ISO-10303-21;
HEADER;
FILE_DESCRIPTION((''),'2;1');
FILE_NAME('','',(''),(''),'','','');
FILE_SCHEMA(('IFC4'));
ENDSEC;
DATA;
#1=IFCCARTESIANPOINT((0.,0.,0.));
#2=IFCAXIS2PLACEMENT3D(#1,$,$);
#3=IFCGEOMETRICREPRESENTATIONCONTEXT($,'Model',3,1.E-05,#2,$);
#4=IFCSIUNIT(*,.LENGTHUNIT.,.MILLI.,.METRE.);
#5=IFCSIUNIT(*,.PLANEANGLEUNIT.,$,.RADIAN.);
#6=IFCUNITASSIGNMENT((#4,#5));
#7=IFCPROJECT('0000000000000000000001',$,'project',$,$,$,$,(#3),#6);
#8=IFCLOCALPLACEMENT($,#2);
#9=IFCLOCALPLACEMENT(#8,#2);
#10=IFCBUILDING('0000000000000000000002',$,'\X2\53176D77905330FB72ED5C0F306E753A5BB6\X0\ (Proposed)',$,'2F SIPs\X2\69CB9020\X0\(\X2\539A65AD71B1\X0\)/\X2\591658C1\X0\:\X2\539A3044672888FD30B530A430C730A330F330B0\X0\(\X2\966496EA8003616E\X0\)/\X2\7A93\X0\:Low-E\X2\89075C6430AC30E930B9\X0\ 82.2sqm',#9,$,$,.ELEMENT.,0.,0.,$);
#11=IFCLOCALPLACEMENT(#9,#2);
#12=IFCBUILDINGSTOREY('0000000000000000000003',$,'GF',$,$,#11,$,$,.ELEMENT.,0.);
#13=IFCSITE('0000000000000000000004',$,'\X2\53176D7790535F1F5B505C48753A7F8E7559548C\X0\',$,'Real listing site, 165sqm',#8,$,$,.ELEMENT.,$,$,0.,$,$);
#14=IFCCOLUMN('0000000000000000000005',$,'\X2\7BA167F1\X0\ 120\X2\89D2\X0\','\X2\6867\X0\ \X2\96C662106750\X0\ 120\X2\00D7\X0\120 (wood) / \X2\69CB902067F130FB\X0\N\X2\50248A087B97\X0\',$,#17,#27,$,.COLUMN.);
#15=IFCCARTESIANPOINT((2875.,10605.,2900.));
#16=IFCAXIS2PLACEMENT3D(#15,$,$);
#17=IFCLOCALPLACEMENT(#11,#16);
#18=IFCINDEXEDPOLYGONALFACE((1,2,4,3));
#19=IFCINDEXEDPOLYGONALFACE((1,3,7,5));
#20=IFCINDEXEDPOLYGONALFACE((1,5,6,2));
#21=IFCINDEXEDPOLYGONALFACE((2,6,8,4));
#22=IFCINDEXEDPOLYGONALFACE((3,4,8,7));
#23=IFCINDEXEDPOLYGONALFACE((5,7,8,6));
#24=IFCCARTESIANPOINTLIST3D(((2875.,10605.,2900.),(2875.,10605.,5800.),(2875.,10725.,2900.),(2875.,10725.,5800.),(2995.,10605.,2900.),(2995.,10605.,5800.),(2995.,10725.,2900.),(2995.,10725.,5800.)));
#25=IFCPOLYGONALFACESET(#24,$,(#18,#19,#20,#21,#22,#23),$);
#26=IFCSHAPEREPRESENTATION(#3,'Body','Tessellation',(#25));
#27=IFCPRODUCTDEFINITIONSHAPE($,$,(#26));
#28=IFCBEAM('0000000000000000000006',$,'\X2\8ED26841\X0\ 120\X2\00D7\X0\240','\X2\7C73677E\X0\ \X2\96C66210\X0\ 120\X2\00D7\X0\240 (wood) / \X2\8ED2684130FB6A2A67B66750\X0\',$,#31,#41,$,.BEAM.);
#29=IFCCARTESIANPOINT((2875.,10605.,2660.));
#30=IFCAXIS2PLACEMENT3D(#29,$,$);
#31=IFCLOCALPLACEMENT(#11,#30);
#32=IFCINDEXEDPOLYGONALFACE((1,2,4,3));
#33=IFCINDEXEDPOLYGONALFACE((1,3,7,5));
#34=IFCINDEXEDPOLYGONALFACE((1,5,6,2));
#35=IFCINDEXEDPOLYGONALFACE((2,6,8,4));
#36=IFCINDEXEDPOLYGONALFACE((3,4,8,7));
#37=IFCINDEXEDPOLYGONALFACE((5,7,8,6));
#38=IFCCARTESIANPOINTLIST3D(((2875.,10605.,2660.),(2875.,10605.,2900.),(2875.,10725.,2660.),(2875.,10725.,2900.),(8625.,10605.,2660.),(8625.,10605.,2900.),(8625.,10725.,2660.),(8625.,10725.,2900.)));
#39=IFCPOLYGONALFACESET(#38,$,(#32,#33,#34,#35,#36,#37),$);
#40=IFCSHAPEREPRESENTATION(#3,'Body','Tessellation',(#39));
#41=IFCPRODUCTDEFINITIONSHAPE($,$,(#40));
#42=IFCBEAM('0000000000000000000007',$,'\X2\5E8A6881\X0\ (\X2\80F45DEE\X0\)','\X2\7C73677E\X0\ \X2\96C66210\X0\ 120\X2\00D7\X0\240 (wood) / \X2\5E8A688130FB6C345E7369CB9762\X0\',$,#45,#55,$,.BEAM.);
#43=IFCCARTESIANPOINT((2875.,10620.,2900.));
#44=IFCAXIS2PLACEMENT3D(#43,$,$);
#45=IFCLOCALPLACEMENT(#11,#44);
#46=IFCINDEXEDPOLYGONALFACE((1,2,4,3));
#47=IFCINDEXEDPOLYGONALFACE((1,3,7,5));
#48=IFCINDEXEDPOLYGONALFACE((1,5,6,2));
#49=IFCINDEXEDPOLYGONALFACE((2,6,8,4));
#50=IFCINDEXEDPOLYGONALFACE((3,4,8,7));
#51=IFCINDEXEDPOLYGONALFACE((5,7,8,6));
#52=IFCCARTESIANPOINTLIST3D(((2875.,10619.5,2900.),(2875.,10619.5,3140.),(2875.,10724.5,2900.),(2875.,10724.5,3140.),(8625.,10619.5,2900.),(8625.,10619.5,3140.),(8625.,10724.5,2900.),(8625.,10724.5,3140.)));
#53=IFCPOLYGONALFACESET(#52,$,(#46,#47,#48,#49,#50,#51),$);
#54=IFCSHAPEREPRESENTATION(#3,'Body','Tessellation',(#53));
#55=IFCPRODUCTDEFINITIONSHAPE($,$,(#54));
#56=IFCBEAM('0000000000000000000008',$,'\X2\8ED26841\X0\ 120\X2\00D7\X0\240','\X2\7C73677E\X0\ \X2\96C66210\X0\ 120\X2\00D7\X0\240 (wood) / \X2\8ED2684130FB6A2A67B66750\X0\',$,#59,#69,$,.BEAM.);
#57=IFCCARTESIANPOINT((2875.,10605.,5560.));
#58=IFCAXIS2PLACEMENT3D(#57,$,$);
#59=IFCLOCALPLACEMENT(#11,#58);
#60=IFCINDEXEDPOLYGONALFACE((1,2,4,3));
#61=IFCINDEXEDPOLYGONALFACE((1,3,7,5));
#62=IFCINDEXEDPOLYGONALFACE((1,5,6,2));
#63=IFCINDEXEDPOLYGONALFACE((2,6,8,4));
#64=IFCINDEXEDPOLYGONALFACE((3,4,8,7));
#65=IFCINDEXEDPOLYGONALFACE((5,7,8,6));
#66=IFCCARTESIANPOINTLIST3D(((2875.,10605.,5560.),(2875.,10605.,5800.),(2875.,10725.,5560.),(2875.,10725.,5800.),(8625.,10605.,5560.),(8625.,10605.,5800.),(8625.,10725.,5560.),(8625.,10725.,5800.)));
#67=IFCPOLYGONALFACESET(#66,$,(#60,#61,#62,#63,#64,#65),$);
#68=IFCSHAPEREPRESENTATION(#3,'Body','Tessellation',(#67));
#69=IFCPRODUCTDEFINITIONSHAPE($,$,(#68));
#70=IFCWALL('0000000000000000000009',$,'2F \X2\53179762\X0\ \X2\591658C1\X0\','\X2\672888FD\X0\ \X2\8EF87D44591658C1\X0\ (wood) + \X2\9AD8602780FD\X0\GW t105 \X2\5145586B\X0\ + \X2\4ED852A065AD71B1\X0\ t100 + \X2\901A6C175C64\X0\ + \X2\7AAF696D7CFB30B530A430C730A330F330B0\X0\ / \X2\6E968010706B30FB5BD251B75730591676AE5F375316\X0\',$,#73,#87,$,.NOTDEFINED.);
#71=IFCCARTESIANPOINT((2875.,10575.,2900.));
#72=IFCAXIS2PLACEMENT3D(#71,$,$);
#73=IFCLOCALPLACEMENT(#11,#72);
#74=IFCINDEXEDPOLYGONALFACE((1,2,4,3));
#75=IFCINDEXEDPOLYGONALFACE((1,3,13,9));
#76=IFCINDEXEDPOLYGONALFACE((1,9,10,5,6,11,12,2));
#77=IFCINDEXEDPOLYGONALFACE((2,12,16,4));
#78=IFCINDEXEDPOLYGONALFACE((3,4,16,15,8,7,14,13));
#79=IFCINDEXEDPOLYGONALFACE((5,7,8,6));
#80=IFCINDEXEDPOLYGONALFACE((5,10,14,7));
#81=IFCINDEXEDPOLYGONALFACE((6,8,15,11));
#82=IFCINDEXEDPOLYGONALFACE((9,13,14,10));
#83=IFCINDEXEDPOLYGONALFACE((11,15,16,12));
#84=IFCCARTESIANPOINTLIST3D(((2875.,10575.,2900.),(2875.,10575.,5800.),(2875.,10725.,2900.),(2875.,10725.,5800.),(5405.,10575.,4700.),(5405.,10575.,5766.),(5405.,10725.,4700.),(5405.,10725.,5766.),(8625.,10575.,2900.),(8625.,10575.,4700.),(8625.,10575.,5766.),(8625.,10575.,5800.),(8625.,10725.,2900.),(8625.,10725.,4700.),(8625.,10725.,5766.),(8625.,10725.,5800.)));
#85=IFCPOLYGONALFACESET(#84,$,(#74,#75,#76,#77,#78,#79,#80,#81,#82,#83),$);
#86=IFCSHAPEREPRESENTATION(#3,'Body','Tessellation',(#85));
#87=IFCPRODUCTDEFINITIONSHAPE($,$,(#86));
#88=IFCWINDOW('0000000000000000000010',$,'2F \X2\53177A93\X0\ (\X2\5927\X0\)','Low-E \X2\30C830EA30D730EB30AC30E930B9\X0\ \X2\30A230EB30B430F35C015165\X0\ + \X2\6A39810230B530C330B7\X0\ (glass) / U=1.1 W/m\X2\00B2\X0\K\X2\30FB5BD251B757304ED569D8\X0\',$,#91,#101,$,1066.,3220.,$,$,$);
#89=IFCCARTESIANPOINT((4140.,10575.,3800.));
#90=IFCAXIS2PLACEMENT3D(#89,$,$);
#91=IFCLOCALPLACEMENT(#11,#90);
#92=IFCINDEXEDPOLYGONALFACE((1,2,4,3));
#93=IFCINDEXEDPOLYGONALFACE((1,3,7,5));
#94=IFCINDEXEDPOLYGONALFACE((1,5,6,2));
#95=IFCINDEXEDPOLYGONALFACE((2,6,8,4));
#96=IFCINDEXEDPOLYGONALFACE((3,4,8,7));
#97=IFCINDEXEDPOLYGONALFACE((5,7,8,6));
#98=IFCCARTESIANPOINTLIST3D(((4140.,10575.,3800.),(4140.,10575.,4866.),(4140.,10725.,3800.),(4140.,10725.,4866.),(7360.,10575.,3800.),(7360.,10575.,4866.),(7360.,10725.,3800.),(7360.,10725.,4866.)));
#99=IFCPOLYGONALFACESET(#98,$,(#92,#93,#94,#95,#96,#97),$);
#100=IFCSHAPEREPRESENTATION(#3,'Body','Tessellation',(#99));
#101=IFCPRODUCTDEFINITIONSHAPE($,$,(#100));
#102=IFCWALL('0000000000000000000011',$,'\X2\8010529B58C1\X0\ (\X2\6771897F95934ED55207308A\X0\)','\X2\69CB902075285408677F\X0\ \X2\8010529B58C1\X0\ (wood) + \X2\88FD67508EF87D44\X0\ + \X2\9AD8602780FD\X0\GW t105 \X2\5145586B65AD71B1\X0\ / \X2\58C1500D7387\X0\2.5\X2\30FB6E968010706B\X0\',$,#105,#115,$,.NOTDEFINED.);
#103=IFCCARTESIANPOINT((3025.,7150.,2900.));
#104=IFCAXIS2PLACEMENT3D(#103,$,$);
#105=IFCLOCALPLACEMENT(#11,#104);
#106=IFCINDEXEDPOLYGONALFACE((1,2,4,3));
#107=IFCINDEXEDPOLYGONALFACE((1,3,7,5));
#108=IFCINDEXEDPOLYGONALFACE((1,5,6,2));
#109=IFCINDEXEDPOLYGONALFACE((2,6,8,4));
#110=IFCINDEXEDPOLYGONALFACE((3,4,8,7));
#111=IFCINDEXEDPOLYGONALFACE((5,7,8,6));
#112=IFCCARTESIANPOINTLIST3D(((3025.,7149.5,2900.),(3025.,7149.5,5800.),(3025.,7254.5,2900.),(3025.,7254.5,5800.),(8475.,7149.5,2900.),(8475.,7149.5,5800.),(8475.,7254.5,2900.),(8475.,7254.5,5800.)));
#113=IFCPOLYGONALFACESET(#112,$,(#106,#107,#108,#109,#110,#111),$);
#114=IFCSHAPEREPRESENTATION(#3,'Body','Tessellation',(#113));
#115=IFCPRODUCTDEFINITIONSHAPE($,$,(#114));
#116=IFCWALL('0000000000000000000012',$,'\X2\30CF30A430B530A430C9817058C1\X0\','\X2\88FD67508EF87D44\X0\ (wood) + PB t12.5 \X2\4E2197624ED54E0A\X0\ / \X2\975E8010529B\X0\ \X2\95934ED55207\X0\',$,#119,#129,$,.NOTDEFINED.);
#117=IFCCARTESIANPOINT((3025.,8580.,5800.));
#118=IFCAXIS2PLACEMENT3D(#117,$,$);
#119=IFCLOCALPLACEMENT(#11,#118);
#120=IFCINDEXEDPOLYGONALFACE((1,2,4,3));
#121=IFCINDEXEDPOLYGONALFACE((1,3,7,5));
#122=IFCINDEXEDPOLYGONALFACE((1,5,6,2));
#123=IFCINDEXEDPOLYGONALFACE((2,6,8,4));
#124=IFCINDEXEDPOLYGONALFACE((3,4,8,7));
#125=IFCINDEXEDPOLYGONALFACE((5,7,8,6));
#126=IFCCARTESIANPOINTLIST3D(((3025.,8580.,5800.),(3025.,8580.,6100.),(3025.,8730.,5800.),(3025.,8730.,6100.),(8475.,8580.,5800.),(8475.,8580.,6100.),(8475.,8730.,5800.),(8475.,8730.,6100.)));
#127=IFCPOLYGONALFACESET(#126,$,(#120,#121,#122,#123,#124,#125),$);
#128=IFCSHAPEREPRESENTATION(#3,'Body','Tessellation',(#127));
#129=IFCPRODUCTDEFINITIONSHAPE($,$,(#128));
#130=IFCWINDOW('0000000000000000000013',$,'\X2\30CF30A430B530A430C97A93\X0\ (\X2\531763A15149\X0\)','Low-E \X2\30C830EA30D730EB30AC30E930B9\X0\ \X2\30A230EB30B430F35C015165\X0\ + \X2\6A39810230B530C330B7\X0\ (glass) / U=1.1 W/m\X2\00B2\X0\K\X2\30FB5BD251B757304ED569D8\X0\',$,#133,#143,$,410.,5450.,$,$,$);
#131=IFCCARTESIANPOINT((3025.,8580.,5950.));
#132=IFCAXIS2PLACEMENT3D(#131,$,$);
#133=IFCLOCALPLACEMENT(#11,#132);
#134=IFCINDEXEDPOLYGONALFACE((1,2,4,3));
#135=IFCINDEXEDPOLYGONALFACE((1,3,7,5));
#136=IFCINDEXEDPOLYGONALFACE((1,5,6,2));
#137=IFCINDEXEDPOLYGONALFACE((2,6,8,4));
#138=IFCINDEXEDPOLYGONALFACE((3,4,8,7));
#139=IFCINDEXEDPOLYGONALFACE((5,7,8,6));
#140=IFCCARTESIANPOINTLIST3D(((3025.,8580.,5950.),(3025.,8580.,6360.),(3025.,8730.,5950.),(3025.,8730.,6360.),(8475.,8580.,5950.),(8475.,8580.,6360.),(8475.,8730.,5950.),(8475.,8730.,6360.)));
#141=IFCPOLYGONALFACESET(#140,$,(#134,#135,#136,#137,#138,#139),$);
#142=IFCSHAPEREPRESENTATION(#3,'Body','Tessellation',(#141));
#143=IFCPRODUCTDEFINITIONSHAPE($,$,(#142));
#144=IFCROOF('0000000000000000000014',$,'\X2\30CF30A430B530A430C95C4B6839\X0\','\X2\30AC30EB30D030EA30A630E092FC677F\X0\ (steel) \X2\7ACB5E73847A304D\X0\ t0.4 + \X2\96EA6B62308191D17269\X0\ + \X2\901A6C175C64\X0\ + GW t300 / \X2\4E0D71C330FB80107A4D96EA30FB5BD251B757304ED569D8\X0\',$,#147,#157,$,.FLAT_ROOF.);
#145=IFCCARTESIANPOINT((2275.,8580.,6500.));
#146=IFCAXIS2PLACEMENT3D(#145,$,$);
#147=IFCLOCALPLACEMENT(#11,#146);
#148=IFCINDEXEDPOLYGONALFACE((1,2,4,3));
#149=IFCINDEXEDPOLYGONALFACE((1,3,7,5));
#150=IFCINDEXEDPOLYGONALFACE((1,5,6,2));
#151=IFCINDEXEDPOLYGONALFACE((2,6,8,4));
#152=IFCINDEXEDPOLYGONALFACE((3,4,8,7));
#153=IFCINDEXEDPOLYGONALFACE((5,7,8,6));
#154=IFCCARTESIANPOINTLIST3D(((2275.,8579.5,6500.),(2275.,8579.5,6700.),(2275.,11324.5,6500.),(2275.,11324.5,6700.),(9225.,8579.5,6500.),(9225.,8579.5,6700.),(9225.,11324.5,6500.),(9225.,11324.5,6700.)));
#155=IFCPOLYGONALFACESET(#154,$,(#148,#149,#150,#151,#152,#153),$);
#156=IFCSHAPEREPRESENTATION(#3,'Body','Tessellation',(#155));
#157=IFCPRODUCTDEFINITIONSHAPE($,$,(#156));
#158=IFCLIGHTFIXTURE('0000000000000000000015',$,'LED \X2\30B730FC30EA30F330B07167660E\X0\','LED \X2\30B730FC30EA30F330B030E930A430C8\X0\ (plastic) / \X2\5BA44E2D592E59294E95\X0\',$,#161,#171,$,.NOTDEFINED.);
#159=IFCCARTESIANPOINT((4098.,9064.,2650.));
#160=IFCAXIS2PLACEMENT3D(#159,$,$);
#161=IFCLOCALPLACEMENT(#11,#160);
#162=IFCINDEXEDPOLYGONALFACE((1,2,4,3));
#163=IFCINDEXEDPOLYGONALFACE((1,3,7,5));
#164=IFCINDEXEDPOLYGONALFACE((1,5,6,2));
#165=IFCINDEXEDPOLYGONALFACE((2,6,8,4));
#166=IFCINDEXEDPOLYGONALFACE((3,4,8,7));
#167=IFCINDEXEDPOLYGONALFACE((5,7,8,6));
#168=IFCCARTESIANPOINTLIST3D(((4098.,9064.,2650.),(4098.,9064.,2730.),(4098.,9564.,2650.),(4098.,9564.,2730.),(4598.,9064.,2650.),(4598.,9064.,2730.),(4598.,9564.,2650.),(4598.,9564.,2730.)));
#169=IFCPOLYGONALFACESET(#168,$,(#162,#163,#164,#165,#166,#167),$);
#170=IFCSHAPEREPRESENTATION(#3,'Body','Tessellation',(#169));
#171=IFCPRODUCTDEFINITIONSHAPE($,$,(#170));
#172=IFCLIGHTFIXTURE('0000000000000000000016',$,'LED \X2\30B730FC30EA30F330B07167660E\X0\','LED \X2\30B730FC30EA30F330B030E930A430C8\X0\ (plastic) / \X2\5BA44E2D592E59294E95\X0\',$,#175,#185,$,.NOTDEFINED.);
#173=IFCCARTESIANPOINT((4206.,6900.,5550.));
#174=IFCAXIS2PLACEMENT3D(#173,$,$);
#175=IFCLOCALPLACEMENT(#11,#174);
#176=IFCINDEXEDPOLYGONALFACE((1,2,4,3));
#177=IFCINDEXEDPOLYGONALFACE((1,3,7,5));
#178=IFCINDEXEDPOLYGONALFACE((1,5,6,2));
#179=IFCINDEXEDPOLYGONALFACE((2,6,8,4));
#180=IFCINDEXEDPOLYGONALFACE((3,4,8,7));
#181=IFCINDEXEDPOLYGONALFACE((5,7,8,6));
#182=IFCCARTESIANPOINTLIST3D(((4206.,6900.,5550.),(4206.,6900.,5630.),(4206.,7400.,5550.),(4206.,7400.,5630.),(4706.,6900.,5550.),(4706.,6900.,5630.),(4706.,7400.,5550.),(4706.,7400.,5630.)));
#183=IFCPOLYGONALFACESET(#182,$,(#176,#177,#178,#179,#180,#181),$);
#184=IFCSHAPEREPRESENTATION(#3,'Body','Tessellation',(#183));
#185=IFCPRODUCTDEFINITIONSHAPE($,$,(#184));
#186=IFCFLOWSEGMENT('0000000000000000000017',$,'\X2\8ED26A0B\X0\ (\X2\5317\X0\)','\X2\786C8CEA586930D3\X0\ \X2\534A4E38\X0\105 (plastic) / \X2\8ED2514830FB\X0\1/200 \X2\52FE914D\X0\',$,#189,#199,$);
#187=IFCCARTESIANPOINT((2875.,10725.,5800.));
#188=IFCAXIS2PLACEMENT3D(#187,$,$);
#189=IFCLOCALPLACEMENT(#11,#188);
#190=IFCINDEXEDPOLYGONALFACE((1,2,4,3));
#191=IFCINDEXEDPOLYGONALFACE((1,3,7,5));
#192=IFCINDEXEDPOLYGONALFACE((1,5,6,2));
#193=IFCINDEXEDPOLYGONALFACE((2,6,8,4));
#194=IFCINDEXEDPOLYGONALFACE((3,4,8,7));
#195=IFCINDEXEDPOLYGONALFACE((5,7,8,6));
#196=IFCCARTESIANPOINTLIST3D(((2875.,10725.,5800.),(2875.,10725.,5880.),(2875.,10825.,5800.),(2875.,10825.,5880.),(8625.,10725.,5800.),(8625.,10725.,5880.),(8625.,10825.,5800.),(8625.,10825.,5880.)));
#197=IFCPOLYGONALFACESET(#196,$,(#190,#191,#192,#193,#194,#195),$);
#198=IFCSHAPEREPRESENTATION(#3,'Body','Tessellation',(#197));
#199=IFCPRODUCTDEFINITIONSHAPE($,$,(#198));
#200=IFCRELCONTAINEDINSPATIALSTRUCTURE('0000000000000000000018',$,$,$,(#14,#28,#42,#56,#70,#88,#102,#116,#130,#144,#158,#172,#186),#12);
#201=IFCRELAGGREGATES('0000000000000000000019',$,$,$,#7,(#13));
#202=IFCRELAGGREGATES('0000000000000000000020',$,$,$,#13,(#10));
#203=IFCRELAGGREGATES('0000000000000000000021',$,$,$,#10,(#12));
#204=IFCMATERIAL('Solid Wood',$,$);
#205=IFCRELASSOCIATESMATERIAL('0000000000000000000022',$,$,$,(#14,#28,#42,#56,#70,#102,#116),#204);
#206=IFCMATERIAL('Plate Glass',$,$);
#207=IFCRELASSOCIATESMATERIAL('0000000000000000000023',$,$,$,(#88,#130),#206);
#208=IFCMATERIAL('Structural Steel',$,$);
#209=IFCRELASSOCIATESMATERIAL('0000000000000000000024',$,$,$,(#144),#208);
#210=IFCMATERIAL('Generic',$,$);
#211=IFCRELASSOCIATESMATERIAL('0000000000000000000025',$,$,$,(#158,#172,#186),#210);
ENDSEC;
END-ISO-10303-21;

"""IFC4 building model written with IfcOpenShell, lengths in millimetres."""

from ifc_helpers import new_model, si_unit, frame, frame_2d, origin, place, context, project, spatial, rectangle, extrude, material, element, fill, save


model = new_model("IFC4")

# Units and contexts
model_context = context("Model", 3, precision=1e-05, world=origin())
ifc_project = project(units=[si_unit("LENGTHUNIT", "METRE", prefix="MILLI"), si_unit("PLANEANGLEUNIT", "RADIAN")], contexts=[model_context])

# Site, building, storey
site_placement = place(None, origin())
site = spatial("IfcSite", under=ifc_project, at=site_placement, Name="北海道弟子屈町美留和", ObjectType="Real listing site, 165sqm", CompositionType="ELEMENT", RefElevation=0.0)
building_placement = place(site_placement, origin())
building = spatial("IfcBuilding", under=site, at=building_placement, Name="北海道・狭小の町家 (Proposed)", ObjectType="2F SIPs構造(厚断熱)/外壁:厚い木製サイディング(除雪考慮)/窓:Low-E複層ガラス 82.2sqm", CompositionType="ELEMENT", ElevationOfRefHeight=0.0, ElevationOfTerrain=0.0)
storey_placement = place(building_placement, origin())
storey = spatial("IfcBuildingStorey", under=building, at=storey_placement, Name="GF", CompositionType="ELEMENT", Elevation=0.0)

# Column
ifc_material_1 = material(Name="Solid Wood")
column_1_placement = place(storey_placement, frame((2875.0, 10605.0, 2900.0)))
element("IfcColumn", 1, at=column_1_placement, inside=storey, material=ifc_material_1, Name="管柱 120角", Description="桧 集成材 120×120 (wood) / 構造柱・N値計算", PredefinedType="COLUMN", context=model_context, shape_type="SweptSolid", body=[
    extrude(rectangle(XDim=120.0, YDim=120.0, at=frame_2d((60.0, 60.0))), frame((2875.0, 10605.0, 2900.0)), (0.0, 0.0, 1.0), 2900.0),
])

# Beams
beam_1_placement = place(storey_placement, frame((2875.0, 10605.0, 2660.0)))
element("IfcBeam", 2, at=beam_1_placement, inside=storey, material=ifc_material_1, Name="軒桁 120×240", Description="米松 集成 120×240 (wood) / 軒桁・横架材", PredefinedType="BEAM", context=model_context, shape_type="SweptSolid", body=[
    extrude(rectangle(XDim=5750.0, YDim=120.0, at=frame_2d((2875.0, 60.0))), frame((2875.0, 10605.0, 2660.0)), (0.0, 0.0, 1.0), 240.0),
])
beam_2_placement = place(storey_placement, frame((2875.0, 10620.0, 2900.0)))
element("IfcBeam", 3, at=beam_2_placement, inside=storey, material=ifc_material_1, Name="床梁 (胴差)", Description="米松 集成 120×240 (wood) / 床梁・水平構面", PredefinedType="BEAM", context=model_context, shape_type="SweptSolid", body=[
    extrude(rectangle(XDim=5750.0, YDim=105.0, at=frame_2d((2875.0, 52.0))), frame((2875.0, 10620.0, 2900.0)), (0.0, 0.0, 1.0), 240.0),
])
beam_3_placement = place(storey_placement, frame((2875.0, 10605.0, 5560.0)))
element("IfcBeam", 4, at=beam_3_placement, inside=storey, material=ifc_material_1, Name="軒桁 120×240", Description="米松 集成 120×240 (wood) / 軒桁・横架材", PredefinedType="BEAM", context=model_context, shape_type="SweptSolid", body=[
    extrude(rectangle(XDim=5750.0, YDim=120.0, at=frame_2d((2875.0, 60.0))), frame((2875.0, 10605.0, 5560.0)), (0.0, 0.0, 1.0), 240.0),
])

# Wall, opening, window
wall_1_placement = place(storey_placement, frame((2875.0, 10575.0, 2900.0)))
wall_1 = element("IfcWall", 5, at=wall_1_placement, inside=storey, material=ifc_material_1, Name="2F 北面 外壁", Description="木製 軸組外壁 (wood) + 高性能GW t105 充填 + 付加断熱 t100 + 通気層 + 窯業系サイディング / 準耐火・寒冷地外皮強化", PredefinedType="NOTDEFINED", context=model_context, shape_type="SweptSolid", body=[
    extrude(rectangle(XDim=5750.0, YDim=150.0, at=frame_2d((2875.0, 75.0))), frame((2875.0, 10575.0, 2900.0)), (0.0, 0.0, 1.0), 2900.0),
])
opening_1_placement = place(storey_placement, frame((4140.0, 10575.0, 3800.0)))
opening_1 = element("IfcOpeningElement", 6, at=opening_1_placement, cuts=wall_1, PredefinedType="NOTDEFINED", context=model_context, shape_type="SweptSolid", body=[
    extrude(rectangle(XDim=3220.0, YDim=150.0, at=frame_2d((1610.0, 75.0))), frame((4140.0, 10575.0, 3800.0)), (0.0, 0.0, 1.0), 1066.0),
])
ifc_material_2 = material(Name="Plate Glass")
window_1_placement = place(storey_placement, frame((4140.0, 10575.0, 3800.0)))
window_1 = element("IfcWindow", 7, at=window_1_placement, inside=storey, material=ifc_material_2, Name="2F 北窓 (大)", Description="Low-E トリプルガラス アルゴン封入 + 樹脂サッシ (glass) / U=1.1 W/m²K・寒冷地仕様", OverallHeight=1066.0, OverallWidth=3220.0, context=model_context, shape_type="SweptSolid", body=[
    extrude(rectangle(XDim=3220.0, YDim=150.0, at=frame_2d((1610.0, 75.0))), frame((4140.0, 10575.0, 3800.0)), (0.0, 0.0, 1.0), 1066.0),
])
fill(opening_1, window_1)

# Wall
wall_2_placement = place(storey_placement, frame((3025.0, 7150.0, 2900.0)))
element("IfcWall", 8, at=wall_2_placement, inside=storey, material=ifc_material_1, Name="耐力壁 (東西間仕切り)", Description="構造用合板 耐力壁 (wood) + 製材軸組 + 高性能GW t105 充填断熱 / 壁倍率2.5・準耐火", PredefinedType="NOTDEFINED", context=model_context, shape_type="SweptSolid", body=[
    extrude(rectangle(XDim=5450.0, YDim=105.0, at=frame_2d((2725.0, 52.0))), frame((3025.0, 7150.0, 2900.0)), (0.0, 0.0, 1.0), 2900.0),
])

# Wall, opening, window
wall_3_placement = place(storey_placement, frame((3025.0, 8580.0, 5800.0)))
wall_3 = element("IfcWall", 9, at=wall_3_placement, inside=storey, material=ifc_material_1, Name="ハイサイド腰壁", Description="製材軸組 (wood) + PB t12.5 両面仕上 / 非耐力 間仕切", PredefinedType="NOTDEFINED", context=model_context, shape_type="SweptSolid", body=[
    extrude(rectangle(XDim=5450.0, YDim=150.0, at=frame_2d((2725.0, 75.0))), frame((3025.0, 8580.0, 5800.0)), (0.0, 0.0, 1.0), 700.0),
])
opening_2_placement = place(storey_placement, frame((3025.0, 8580.0, 5950.0)))
opening_2 = element("IfcOpeningElement", 10, at=opening_2_placement, cuts=wall_3, PredefinedType="NOTDEFINED", context=model_context, shape_type="SweptSolid", body=[
    extrude(rectangle(XDim=5450.0, YDim=150.0, at=frame_2d((2725.0, 75.0))), frame((3025.0, 8580.0, 5950.0)), (0.0, 0.0, 1.0), 410.0),
])
window_2_placement = place(storey_placement, frame((3025.0, 8580.0, 5950.0)))
window_2 = element("IfcWindow", 11, at=window_2_placement, inside=storey, material=ifc_material_2, Name="ハイサイド窓 (北採光)", Description="Low-E トリプルガラス アルゴン封入 + 樹脂サッシ (glass) / U=1.1 W/m²K・寒冷地仕様", OverallHeight=410.0, OverallWidth=5450.0, context=model_context, shape_type="SweptSolid", body=[
    extrude(rectangle(XDim=5450.0, YDim=150.0, at=frame_2d((2725.0, 75.0))), frame((3025.0, 8580.0, 5950.0)), (0.0, 0.0, 1.0), 410.0),
])
fill(opening_2, window_2)

# Roof
ifc_material_3 = material(Name="Structural Steel")
roof_placement = place(storey_placement, frame((2275.0, 8580.0, 6500.0)))
element("IfcRoof", 12, at=roof_placement, inside=storey, material=ifc_material_3, Name="ハイサイド屋根", Description="ガルバリウム鋼板 (steel) 立平葺き t0.4 + 雪止め金物 + 通気層 + GW t300 / 不燃・耐積雪・寒冷地仕様", PredefinedType="FLAT_ROOF", context=model_context, shape_type="SweptSolid", body=[
    extrude(rectangle(XDim=6950.0, YDim=2745.0, at=frame_2d((3475.0, 1372.0))), frame((2275.0, 8580.0, 6500.0)), (0.0, 0.0, 1.0), 200.0),
])

# Light fixtures
ifc_material_4 = material(Name="Generic")
light_fixture_1_placement = place(storey_placement, frame((4098.0, 9064.0, 2650.0)))
element("IfcLightFixture", 13, at=light_fixture_1_placement, inside=storey, material=ifc_material_4, Name="LED シーリング照明", Description="LED シーリングライト (plastic) / 室中央天井", PredefinedType="NOTDEFINED", context=model_context, shape_type="SweptSolid", body=[
    extrude(rectangle(XDim=500.0, YDim=500.0, at=frame_2d((250.0, 250.0))), frame((4098.0, 9064.0, 2650.0)), (0.0, 0.0, 1.0), 80.0),
])
light_fixture_2_placement = place(storey_placement, frame((4206.0, 6900.0, 5550.0)))
element("IfcLightFixture", 14, at=light_fixture_2_placement, inside=storey, material=ifc_material_4, Name="LED シーリング照明", Description="LED シーリングライト (plastic) / 室中央天井", PredefinedType="NOTDEFINED", context=model_context, shape_type="SweptSolid", body=[
    extrude(rectangle(XDim=500.0, YDim=500.0, at=frame_2d((250.0, 250.0))), frame((4206.0, 6900.0, 5550.0)), (0.0, 0.0, 1.0), 80.0),
])

# Flow segment
flow_segment_placement = place(storey_placement, frame((2875.0, 10725.0, 5800.0)))
element("IfcFlowSegment", 15, at=flow_segment_placement, inside=storey, material=ifc_material_4, Name="軒樋 (北)", Description="硬質塩ビ 半丸105 (plastic) / 軒先・1/200 勾配", context=model_context, shape_type="SweptSolid", body=[
    extrude(rectangle(XDim=5750.0, YDim=100.0, at=frame_2d((2875.0, 50.0))), frame((2875.0, 10725.0, 5800.0)), (0.0, 0.0, 1.0), 80.0),
])

save(model, "model.ifc")
